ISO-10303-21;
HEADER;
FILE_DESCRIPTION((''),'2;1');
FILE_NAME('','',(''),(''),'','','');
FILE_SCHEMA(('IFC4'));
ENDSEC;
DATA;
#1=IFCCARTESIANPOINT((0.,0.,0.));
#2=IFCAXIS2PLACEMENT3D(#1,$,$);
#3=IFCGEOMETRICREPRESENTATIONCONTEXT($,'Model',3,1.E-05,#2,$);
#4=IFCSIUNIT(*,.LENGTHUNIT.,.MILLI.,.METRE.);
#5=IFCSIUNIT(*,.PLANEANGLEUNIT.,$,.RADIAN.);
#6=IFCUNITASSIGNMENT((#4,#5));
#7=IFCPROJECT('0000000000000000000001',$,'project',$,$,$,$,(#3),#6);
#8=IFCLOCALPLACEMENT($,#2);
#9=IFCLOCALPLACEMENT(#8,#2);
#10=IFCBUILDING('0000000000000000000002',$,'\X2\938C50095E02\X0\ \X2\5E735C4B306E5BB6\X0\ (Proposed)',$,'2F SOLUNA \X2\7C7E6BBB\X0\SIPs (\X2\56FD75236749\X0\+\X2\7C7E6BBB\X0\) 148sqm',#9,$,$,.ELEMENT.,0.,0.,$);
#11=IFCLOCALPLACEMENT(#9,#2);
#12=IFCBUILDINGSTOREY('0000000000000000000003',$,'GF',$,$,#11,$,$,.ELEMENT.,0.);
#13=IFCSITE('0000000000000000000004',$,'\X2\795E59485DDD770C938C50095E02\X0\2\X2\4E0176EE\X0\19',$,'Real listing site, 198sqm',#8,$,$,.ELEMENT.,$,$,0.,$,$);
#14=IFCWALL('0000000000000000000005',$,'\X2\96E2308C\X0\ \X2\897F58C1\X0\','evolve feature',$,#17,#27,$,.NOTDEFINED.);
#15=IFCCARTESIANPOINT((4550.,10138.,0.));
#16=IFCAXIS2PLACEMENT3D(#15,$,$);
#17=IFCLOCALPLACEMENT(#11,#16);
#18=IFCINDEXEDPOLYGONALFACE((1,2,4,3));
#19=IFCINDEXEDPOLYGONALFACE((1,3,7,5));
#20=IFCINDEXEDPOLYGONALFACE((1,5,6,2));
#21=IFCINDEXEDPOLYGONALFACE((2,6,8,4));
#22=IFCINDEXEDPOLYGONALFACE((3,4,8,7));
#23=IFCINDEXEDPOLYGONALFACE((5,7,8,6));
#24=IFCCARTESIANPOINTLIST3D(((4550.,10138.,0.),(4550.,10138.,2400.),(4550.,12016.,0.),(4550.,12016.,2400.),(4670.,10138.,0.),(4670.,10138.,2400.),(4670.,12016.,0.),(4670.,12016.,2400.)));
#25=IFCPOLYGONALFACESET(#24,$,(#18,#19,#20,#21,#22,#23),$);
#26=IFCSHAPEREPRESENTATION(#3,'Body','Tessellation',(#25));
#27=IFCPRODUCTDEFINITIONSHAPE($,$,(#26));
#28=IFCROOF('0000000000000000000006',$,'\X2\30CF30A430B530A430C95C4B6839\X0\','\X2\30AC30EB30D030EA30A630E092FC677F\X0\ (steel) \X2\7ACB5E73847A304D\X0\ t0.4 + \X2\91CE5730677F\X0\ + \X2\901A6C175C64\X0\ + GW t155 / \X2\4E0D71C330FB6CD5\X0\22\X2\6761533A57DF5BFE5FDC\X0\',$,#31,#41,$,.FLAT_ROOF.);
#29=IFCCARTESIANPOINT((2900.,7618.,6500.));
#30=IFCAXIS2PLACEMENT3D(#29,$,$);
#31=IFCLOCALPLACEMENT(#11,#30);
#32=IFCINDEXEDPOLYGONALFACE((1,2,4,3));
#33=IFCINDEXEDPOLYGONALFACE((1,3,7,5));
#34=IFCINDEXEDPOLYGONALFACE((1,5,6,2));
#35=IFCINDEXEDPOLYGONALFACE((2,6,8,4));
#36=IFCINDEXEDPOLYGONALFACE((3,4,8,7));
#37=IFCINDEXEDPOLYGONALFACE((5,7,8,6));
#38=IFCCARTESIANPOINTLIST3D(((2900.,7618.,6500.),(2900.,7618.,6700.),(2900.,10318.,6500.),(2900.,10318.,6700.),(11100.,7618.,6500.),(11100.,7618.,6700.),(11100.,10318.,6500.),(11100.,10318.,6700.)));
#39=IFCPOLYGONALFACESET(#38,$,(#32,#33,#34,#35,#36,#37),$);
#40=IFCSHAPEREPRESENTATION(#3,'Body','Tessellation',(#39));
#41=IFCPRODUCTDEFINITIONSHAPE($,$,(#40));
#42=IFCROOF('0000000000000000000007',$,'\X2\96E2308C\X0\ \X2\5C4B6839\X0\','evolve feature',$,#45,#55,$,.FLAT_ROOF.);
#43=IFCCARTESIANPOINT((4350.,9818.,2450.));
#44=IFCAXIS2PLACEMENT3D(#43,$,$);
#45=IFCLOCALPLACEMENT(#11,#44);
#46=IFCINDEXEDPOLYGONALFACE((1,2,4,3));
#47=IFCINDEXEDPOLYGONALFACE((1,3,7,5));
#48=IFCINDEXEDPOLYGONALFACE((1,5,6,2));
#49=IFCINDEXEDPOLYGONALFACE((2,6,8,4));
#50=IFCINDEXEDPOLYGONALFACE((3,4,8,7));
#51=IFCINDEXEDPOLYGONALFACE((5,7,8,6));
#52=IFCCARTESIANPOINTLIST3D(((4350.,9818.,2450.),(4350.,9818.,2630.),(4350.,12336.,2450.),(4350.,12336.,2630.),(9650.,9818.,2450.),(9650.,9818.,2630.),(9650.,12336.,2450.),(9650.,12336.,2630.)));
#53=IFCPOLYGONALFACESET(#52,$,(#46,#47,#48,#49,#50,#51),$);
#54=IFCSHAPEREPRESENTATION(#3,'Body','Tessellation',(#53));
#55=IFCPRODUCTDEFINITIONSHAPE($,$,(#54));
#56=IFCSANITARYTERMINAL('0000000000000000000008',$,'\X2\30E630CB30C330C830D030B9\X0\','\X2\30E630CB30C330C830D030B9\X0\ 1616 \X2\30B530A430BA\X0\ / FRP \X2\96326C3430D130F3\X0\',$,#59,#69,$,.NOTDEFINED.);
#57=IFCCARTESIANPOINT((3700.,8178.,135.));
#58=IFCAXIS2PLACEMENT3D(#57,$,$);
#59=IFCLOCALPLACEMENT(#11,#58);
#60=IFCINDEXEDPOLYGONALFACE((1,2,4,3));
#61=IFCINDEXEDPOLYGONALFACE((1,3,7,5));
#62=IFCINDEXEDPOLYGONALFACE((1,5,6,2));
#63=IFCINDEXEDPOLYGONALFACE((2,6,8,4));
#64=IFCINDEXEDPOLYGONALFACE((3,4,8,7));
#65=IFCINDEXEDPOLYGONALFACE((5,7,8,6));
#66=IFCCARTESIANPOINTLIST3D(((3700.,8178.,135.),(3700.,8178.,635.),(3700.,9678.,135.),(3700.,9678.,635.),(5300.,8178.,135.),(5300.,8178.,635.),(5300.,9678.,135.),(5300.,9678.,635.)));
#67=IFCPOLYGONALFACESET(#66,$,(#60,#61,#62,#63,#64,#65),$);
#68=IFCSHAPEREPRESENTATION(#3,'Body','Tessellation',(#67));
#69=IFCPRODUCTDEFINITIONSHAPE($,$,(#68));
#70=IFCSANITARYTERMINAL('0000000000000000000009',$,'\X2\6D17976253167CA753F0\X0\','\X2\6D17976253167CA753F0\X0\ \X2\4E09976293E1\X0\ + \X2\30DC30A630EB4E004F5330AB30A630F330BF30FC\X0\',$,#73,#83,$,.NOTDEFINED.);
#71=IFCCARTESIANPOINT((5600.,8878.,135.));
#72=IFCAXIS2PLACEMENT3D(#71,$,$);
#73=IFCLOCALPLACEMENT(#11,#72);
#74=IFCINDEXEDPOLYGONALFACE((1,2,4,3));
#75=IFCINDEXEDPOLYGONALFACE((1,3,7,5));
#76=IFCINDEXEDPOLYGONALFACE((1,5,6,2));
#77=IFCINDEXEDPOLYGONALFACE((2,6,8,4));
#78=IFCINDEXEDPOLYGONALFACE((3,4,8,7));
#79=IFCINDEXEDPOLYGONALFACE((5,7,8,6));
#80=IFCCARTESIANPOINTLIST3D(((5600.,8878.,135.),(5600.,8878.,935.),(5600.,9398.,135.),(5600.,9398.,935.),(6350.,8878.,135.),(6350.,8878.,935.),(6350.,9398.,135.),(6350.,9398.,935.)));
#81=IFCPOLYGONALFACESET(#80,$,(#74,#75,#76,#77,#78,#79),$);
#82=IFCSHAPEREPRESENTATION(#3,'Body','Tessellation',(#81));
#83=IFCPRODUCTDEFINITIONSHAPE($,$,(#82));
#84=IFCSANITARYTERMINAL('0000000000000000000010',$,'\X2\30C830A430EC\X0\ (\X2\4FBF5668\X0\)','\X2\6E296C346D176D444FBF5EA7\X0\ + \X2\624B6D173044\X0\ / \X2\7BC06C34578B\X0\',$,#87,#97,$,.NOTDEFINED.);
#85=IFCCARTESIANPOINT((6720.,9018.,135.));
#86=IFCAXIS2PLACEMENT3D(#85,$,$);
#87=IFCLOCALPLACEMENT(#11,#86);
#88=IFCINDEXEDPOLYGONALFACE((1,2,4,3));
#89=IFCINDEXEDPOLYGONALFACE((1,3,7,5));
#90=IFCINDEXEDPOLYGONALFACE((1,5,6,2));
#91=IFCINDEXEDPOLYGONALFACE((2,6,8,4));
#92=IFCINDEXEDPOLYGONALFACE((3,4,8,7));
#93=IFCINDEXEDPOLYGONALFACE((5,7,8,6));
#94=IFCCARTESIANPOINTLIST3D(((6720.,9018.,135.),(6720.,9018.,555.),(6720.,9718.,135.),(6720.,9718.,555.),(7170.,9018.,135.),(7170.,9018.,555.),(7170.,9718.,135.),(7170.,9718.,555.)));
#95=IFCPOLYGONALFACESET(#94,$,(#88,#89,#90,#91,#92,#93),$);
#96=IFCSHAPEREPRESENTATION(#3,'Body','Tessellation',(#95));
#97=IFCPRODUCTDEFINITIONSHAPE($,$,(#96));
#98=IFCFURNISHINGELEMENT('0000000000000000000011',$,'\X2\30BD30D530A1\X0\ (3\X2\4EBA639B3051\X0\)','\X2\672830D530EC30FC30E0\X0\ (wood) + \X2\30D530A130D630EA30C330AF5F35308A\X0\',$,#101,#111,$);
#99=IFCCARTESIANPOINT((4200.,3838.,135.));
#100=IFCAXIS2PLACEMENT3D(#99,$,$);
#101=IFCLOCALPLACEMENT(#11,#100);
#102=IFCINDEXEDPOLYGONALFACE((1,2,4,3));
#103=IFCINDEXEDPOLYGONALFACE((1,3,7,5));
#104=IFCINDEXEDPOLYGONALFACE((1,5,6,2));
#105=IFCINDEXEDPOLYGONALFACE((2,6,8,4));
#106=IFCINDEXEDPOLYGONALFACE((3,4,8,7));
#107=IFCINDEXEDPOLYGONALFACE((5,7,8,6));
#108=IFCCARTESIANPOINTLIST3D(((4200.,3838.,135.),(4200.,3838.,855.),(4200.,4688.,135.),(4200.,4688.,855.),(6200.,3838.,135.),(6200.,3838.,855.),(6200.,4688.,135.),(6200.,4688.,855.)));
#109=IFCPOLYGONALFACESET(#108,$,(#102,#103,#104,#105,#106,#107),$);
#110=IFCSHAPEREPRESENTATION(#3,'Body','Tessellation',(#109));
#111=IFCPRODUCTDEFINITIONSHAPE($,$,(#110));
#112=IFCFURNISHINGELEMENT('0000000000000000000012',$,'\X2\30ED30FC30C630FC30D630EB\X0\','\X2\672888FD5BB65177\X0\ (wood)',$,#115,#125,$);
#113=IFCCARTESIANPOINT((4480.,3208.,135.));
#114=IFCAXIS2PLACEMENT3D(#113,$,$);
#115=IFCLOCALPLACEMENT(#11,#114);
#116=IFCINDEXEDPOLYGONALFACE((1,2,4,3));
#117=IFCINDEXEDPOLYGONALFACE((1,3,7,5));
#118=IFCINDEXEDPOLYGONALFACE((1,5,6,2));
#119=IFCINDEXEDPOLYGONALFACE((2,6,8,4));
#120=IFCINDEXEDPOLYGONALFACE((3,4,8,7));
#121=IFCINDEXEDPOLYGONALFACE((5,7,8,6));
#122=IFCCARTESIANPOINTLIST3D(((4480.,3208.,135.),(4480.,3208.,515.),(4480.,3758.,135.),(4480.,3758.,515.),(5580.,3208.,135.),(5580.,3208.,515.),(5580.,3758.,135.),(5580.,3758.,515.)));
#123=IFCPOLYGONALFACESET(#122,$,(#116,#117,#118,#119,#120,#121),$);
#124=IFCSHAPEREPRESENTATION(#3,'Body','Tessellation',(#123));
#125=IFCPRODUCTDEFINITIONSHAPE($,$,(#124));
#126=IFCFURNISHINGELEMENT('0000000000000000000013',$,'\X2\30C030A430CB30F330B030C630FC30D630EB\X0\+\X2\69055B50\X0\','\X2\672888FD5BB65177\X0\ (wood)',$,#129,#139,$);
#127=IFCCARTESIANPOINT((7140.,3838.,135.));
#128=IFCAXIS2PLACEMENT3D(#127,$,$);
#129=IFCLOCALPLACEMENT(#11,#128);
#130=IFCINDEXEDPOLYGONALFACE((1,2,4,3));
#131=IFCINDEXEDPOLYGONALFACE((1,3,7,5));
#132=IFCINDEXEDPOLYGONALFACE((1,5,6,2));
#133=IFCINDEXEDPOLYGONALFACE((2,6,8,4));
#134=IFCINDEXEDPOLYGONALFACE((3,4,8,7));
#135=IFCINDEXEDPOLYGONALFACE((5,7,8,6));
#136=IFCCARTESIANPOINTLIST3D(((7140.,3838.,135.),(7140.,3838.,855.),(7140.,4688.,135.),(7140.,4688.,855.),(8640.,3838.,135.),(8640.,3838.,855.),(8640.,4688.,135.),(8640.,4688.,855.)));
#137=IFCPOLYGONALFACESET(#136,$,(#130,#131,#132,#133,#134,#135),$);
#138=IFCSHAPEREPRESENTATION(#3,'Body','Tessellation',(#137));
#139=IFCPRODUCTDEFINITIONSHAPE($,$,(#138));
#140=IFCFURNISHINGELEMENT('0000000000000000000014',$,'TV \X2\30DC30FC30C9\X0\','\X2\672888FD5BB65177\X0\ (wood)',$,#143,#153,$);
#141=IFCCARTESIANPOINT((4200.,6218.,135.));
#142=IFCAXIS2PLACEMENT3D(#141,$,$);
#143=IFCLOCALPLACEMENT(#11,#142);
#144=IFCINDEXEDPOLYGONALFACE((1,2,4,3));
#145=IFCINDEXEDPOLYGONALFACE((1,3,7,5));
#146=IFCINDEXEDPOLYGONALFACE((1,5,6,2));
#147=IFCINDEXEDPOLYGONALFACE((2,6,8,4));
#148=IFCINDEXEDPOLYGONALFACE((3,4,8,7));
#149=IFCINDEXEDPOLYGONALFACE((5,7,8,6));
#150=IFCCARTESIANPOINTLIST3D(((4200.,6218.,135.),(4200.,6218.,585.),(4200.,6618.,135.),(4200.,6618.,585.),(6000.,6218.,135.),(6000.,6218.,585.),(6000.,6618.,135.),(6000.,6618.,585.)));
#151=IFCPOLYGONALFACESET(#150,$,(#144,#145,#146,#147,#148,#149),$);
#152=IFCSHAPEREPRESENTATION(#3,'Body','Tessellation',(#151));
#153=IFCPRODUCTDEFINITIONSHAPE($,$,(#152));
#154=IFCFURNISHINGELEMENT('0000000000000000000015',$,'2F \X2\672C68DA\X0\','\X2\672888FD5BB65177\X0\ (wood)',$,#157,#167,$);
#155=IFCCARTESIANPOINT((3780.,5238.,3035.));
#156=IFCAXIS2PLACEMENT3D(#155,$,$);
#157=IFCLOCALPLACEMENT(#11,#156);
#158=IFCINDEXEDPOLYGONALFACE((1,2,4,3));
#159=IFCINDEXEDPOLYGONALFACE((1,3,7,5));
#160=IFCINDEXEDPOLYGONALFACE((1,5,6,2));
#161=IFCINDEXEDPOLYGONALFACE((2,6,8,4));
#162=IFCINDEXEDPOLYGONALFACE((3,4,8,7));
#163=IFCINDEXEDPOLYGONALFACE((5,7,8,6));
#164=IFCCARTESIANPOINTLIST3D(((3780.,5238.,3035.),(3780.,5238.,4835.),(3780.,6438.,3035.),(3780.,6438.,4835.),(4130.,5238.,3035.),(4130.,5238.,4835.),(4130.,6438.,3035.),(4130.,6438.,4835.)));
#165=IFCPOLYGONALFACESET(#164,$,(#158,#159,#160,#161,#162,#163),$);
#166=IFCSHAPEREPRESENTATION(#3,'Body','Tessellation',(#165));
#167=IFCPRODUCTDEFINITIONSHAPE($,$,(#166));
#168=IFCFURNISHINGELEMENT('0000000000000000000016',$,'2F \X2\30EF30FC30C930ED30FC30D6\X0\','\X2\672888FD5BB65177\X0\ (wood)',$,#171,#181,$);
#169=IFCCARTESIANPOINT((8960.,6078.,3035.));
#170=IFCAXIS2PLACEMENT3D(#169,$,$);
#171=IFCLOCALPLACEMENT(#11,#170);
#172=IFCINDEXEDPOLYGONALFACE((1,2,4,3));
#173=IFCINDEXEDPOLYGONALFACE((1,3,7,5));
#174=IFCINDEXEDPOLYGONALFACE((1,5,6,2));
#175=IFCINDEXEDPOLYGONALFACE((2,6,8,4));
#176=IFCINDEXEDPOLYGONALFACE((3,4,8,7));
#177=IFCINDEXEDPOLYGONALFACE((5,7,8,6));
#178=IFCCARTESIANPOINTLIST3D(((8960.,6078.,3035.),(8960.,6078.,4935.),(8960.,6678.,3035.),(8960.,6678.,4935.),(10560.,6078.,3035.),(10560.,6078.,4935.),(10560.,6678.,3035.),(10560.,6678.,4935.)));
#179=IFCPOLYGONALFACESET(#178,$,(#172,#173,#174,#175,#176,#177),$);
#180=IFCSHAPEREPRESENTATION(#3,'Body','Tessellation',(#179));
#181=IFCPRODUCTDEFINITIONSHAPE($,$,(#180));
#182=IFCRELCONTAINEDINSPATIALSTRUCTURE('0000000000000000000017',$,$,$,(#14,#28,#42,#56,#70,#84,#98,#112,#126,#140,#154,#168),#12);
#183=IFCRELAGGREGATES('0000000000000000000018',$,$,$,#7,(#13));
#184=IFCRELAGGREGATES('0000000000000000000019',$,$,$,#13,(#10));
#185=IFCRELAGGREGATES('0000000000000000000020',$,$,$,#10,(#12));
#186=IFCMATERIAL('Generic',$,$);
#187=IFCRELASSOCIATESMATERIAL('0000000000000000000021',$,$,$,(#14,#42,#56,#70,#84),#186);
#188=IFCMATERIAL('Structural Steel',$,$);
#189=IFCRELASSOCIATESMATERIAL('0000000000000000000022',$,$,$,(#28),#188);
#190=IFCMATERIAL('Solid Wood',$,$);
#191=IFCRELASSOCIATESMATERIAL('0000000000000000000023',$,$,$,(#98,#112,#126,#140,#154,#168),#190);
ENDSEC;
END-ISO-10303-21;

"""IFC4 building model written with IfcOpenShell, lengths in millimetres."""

from ifc_helpers import new_model, si_unit, frame, frame_2d, origin, place, context, project, spatial, rectangle, extrude, material, element, save


model = new_model("IFC4")

# Units and contexts
model_context = context("Model", 3, precision=1e-05, world=origin())
ifc_project = project(units=[si_unit("LENGTHUNIT", "METRE", prefix="MILLI"), si_unit("PLANEANGLEUNIT", "RADIAN")], contexts=[model_context])

# Site, building, storey
site_placement = place(None, origin())
site = spatial("IfcSite", under=ifc_project, at=site_placement, Name="神奈川県鎌倉市2丁目19", ObjectType="Real listing site, 198sqm", CompositionType="ELEMENT", RefElevation=0.0)
building_placement = place(site_placement, origin())
building = spatial("IfcBuilding", under=site, at=building_placement, Name="鎌倉市 平屋の家 (Proposed)", ObjectType="2F SOLUNA 籾殻SIPs (国産杉+籾殻) 148sqm", CompositionType="ELEMENT", ElevationOfRefHeight=0.0, ElevationOfTerrain=0.0)
storey_placement = place(building_placement, origin())
storey = spatial("IfcBuildingStorey", under=building, at=storey_placement, Name="GF", CompositionType="ELEMENT", Elevation=0.0)

# Shared definitions
ifc_material_1 = material(Name="Generic")

# Shared definitions
ifc_material_2 = material(Name="Solid Wood")

# Wall
wall_1_placement = place(storey_placement, frame((4550.0, 10138.0, 0.0)))
element("IfcWall", 1, at=wall_1_placement, inside=storey, material=ifc_material_1, Name="離れ 西壁", Description="evolve feature", PredefinedType="NOTDEFINED", context=model_context, shape_type="SweptSolid", body=[
    extrude(rectangle(XDim=120.0, YDim=1878.0, at=frame_2d((60.0, 939.0))), frame((4550.0, 10138.0, 0.0)), (0.0, 0.0, 1.0), 2400.0),
])

# Roofs
ifc_material_3 = material(Name="Structural Steel")
roof_1_placement = place(storey_placement, frame((2900.0, 7618.0, 6500.0)))
element("IfcRoof", 2, at=roof_1_placement, inside=storey, material=ifc_material_3, Name="ハイサイド屋根", Description="ガルバリウム鋼板 (steel) 立平葺き t0.4 + 野地板 + 通気層 + GW t155 / 不燃・法22条区域対応", PredefinedType="FLAT_ROOF", context=model_context, shape_type="SweptSolid", body=[
    extrude(rectangle(XDim=8200.0, YDim=2700.0, at=frame_2d((4100.0, 1350.0))), frame((2900.0, 7618.0, 6500.0)), (0.0, 0.0, 1.0), 200.0),
])
roof_2_placement = place(storey_placement, frame((4350.0, 9818.0, 2450.0)))
element("IfcRoof", 3, at=roof_2_placement, inside=storey, material=ifc_material_1, Name="離れ 屋根", Description="evolve feature", PredefinedType="FLAT_ROOF", context=model_context, shape_type="SweptSolid", body=[
    extrude(rectangle(XDim=5300.0, YDim=2518.0, at=frame_2d((2650.0, 1259.0))), frame((4350.0, 9818.0, 2450.0)), (0.0, 0.0, 1.0), 180.0),
])

# Sanitary terminals
sanitary_terminal_1_placement = place(storey_placement, frame((3700.0, 8178.0, 135.0)))
element("IfcSanitaryTerminal", 4, at=sanitary_terminal_1_placement, inside=storey, material=ifc_material_1, Name="ユニットバス", Description="ユニットバス 1616 サイズ / FRP 防水パン", PredefinedType="NOTDEFINED", context=model_context, shape_type="SweptSolid", body=[
    extrude(rectangle(XDim=1600.0, YDim=1500.0, at=frame_2d((800.0, 750.0))), frame((3700.0, 8178.0, 135.0)), (0.0, 0.0, 1.0), 500.0),
])
sanitary_terminal_2_placement = place(storey_placement, frame((5600.0, 8878.0, 135.0)))
element("IfcSanitaryTerminal", 5, at=sanitary_terminal_2_placement, inside=storey, material=ifc_material_1, Name="洗面化粧台", Description="洗面化粧台 三面鏡 + ボウル一体カウンター", PredefinedType="NOTDEFINED", context=model_context, shape_type="SweptSolid", body=[
    extrude(rectangle(XDim=750.0, YDim=520.0, at=frame_2d((375.0, 260.0))), frame((5600.0, 8878.0, 135.0)), (0.0, 0.0, 1.0), 800.0),
])
sanitary_terminal_3_placement = place(storey_placement, frame((6720.0, 9018.0, 135.0)))
element("IfcSanitaryTerminal", 6, at=sanitary_terminal_3_placement, inside=storey, material=ifc_material_1, Name="トイレ (便器)", Description="温水洗浄便座 + 手洗い / 節水型", PredefinedType="NOTDEFINED", context=model_context, shape_type="SweptSolid", body=[
    extrude(rectangle(XDim=450.0, YDim=700.0, at=frame_2d((225.0, 350.0))), frame((6720.0, 9018.0, 135.0)), (0.0, 0.0, 1.0), 420.0),
])

# Furnishing elements
furnishing_1_placement = place(storey_placement, frame((4200.0, 3838.0, 135.0)))
element("IfcFurnishingElement", 7, at=furnishing_1_placement, inside=storey, material=ifc_material_2, Name="ソファ (3人掛け)", Description="木フレーム (wood) + ファブリック張り", context=model_context, shape_type="SweptSolid", body=[
    extrude(rectangle(XDim=2000.0, YDim=850.0, at=frame_2d((1000.0, 425.0))), frame((4200.0, 3838.0, 135.0)), (0.0, 0.0, 1.0), 720.0),
])
furnishing_2_placement = place(storey_placement, frame((4480.0, 3208.0, 135.0)))
element("IfcFurnishingElement", 8, at=furnishing_2_placement, inside=storey, material=ifc_material_2, Name="ローテーブル", Description="木製家具 (wood)", context=model_context, shape_type="SweptSolid", body=[
    extrude(rectangle(XDim=1100.0, YDim=550.0, at=frame_2d((550.0, 275.0))), frame((4480.0, 3208.0, 135.0)), (0.0, 0.0, 1.0), 380.0),
])
furnishing_3_placement = place(storey_placement, frame((7140.0, 3838.0, 135.0)))
element("IfcFurnishingElement", 9, at=furnishing_3_placement, inside=storey, material=ifc_material_2, Name="ダイニングテーブル+椅子", Description="木製家具 (wood)", context=model_context, shape_type="SweptSolid", body=[
    extrude(rectangle(XDim=1500.0, YDim=850.0, at=frame_2d((750.0, 425.0))), frame((7140.0, 3838.0, 135.0)), (0.0, 0.0, 1.0), 720.0),
])
furnishing_4_placement = place(storey_placement, frame((4200.0, 6218.0, 135.0)))
element("IfcFurnishingElement", 10, at=furnishing_4_placement, inside=storey, material=ifc_material_2, Name="TV ボード", Description="木製家具 (wood)", context=model_context, shape_type="SweptSolid", body=[
    extrude(rectangle(XDim=1800.0, YDim=400.0, at=frame_2d((900.0, 200.0))), frame((4200.0, 6218.0, 135.0)), (0.0, 0.0, 1.0), 450.0),
])
furnishing_5_placement = place(storey_placement, frame((3780.0, 5238.0, 3035.0)))
element("IfcFurnishingElement", 11, at=furnishing_5_placement, inside=storey, material=ifc_material_2, Name="2F 本棚", Description="木製家具 (wood)", context=model_context, shape_type="SweptSolid", body=[
    extrude(rectangle(XDim=350.0, YDim=1200.0, at=frame_2d((175.0, 600.0))), frame((3780.0, 5238.0, 3035.0)), (0.0, 0.0, 1.0), 1800.0),
])
furnishing_6_placement = place(storey_placement, frame((8960.0, 6078.0, 3035.0)))
element("IfcFurnishingElement", 12, at=furnishing_6_placement, inside=storey, material=ifc_material_2, Name="2F ワードローブ", Description="木製家具 (wood)", context=model_context, shape_type="SweptSolid", body=[
    extrude(rectangle(XDim=1600.0, YDim=600.0, at=frame_2d((800.0, 300.0))), frame((8960.0, 6078.0, 3035.0)), (0.0, 0.0, 1.0), 1900.0),
])

save(model, "model.ifc")
